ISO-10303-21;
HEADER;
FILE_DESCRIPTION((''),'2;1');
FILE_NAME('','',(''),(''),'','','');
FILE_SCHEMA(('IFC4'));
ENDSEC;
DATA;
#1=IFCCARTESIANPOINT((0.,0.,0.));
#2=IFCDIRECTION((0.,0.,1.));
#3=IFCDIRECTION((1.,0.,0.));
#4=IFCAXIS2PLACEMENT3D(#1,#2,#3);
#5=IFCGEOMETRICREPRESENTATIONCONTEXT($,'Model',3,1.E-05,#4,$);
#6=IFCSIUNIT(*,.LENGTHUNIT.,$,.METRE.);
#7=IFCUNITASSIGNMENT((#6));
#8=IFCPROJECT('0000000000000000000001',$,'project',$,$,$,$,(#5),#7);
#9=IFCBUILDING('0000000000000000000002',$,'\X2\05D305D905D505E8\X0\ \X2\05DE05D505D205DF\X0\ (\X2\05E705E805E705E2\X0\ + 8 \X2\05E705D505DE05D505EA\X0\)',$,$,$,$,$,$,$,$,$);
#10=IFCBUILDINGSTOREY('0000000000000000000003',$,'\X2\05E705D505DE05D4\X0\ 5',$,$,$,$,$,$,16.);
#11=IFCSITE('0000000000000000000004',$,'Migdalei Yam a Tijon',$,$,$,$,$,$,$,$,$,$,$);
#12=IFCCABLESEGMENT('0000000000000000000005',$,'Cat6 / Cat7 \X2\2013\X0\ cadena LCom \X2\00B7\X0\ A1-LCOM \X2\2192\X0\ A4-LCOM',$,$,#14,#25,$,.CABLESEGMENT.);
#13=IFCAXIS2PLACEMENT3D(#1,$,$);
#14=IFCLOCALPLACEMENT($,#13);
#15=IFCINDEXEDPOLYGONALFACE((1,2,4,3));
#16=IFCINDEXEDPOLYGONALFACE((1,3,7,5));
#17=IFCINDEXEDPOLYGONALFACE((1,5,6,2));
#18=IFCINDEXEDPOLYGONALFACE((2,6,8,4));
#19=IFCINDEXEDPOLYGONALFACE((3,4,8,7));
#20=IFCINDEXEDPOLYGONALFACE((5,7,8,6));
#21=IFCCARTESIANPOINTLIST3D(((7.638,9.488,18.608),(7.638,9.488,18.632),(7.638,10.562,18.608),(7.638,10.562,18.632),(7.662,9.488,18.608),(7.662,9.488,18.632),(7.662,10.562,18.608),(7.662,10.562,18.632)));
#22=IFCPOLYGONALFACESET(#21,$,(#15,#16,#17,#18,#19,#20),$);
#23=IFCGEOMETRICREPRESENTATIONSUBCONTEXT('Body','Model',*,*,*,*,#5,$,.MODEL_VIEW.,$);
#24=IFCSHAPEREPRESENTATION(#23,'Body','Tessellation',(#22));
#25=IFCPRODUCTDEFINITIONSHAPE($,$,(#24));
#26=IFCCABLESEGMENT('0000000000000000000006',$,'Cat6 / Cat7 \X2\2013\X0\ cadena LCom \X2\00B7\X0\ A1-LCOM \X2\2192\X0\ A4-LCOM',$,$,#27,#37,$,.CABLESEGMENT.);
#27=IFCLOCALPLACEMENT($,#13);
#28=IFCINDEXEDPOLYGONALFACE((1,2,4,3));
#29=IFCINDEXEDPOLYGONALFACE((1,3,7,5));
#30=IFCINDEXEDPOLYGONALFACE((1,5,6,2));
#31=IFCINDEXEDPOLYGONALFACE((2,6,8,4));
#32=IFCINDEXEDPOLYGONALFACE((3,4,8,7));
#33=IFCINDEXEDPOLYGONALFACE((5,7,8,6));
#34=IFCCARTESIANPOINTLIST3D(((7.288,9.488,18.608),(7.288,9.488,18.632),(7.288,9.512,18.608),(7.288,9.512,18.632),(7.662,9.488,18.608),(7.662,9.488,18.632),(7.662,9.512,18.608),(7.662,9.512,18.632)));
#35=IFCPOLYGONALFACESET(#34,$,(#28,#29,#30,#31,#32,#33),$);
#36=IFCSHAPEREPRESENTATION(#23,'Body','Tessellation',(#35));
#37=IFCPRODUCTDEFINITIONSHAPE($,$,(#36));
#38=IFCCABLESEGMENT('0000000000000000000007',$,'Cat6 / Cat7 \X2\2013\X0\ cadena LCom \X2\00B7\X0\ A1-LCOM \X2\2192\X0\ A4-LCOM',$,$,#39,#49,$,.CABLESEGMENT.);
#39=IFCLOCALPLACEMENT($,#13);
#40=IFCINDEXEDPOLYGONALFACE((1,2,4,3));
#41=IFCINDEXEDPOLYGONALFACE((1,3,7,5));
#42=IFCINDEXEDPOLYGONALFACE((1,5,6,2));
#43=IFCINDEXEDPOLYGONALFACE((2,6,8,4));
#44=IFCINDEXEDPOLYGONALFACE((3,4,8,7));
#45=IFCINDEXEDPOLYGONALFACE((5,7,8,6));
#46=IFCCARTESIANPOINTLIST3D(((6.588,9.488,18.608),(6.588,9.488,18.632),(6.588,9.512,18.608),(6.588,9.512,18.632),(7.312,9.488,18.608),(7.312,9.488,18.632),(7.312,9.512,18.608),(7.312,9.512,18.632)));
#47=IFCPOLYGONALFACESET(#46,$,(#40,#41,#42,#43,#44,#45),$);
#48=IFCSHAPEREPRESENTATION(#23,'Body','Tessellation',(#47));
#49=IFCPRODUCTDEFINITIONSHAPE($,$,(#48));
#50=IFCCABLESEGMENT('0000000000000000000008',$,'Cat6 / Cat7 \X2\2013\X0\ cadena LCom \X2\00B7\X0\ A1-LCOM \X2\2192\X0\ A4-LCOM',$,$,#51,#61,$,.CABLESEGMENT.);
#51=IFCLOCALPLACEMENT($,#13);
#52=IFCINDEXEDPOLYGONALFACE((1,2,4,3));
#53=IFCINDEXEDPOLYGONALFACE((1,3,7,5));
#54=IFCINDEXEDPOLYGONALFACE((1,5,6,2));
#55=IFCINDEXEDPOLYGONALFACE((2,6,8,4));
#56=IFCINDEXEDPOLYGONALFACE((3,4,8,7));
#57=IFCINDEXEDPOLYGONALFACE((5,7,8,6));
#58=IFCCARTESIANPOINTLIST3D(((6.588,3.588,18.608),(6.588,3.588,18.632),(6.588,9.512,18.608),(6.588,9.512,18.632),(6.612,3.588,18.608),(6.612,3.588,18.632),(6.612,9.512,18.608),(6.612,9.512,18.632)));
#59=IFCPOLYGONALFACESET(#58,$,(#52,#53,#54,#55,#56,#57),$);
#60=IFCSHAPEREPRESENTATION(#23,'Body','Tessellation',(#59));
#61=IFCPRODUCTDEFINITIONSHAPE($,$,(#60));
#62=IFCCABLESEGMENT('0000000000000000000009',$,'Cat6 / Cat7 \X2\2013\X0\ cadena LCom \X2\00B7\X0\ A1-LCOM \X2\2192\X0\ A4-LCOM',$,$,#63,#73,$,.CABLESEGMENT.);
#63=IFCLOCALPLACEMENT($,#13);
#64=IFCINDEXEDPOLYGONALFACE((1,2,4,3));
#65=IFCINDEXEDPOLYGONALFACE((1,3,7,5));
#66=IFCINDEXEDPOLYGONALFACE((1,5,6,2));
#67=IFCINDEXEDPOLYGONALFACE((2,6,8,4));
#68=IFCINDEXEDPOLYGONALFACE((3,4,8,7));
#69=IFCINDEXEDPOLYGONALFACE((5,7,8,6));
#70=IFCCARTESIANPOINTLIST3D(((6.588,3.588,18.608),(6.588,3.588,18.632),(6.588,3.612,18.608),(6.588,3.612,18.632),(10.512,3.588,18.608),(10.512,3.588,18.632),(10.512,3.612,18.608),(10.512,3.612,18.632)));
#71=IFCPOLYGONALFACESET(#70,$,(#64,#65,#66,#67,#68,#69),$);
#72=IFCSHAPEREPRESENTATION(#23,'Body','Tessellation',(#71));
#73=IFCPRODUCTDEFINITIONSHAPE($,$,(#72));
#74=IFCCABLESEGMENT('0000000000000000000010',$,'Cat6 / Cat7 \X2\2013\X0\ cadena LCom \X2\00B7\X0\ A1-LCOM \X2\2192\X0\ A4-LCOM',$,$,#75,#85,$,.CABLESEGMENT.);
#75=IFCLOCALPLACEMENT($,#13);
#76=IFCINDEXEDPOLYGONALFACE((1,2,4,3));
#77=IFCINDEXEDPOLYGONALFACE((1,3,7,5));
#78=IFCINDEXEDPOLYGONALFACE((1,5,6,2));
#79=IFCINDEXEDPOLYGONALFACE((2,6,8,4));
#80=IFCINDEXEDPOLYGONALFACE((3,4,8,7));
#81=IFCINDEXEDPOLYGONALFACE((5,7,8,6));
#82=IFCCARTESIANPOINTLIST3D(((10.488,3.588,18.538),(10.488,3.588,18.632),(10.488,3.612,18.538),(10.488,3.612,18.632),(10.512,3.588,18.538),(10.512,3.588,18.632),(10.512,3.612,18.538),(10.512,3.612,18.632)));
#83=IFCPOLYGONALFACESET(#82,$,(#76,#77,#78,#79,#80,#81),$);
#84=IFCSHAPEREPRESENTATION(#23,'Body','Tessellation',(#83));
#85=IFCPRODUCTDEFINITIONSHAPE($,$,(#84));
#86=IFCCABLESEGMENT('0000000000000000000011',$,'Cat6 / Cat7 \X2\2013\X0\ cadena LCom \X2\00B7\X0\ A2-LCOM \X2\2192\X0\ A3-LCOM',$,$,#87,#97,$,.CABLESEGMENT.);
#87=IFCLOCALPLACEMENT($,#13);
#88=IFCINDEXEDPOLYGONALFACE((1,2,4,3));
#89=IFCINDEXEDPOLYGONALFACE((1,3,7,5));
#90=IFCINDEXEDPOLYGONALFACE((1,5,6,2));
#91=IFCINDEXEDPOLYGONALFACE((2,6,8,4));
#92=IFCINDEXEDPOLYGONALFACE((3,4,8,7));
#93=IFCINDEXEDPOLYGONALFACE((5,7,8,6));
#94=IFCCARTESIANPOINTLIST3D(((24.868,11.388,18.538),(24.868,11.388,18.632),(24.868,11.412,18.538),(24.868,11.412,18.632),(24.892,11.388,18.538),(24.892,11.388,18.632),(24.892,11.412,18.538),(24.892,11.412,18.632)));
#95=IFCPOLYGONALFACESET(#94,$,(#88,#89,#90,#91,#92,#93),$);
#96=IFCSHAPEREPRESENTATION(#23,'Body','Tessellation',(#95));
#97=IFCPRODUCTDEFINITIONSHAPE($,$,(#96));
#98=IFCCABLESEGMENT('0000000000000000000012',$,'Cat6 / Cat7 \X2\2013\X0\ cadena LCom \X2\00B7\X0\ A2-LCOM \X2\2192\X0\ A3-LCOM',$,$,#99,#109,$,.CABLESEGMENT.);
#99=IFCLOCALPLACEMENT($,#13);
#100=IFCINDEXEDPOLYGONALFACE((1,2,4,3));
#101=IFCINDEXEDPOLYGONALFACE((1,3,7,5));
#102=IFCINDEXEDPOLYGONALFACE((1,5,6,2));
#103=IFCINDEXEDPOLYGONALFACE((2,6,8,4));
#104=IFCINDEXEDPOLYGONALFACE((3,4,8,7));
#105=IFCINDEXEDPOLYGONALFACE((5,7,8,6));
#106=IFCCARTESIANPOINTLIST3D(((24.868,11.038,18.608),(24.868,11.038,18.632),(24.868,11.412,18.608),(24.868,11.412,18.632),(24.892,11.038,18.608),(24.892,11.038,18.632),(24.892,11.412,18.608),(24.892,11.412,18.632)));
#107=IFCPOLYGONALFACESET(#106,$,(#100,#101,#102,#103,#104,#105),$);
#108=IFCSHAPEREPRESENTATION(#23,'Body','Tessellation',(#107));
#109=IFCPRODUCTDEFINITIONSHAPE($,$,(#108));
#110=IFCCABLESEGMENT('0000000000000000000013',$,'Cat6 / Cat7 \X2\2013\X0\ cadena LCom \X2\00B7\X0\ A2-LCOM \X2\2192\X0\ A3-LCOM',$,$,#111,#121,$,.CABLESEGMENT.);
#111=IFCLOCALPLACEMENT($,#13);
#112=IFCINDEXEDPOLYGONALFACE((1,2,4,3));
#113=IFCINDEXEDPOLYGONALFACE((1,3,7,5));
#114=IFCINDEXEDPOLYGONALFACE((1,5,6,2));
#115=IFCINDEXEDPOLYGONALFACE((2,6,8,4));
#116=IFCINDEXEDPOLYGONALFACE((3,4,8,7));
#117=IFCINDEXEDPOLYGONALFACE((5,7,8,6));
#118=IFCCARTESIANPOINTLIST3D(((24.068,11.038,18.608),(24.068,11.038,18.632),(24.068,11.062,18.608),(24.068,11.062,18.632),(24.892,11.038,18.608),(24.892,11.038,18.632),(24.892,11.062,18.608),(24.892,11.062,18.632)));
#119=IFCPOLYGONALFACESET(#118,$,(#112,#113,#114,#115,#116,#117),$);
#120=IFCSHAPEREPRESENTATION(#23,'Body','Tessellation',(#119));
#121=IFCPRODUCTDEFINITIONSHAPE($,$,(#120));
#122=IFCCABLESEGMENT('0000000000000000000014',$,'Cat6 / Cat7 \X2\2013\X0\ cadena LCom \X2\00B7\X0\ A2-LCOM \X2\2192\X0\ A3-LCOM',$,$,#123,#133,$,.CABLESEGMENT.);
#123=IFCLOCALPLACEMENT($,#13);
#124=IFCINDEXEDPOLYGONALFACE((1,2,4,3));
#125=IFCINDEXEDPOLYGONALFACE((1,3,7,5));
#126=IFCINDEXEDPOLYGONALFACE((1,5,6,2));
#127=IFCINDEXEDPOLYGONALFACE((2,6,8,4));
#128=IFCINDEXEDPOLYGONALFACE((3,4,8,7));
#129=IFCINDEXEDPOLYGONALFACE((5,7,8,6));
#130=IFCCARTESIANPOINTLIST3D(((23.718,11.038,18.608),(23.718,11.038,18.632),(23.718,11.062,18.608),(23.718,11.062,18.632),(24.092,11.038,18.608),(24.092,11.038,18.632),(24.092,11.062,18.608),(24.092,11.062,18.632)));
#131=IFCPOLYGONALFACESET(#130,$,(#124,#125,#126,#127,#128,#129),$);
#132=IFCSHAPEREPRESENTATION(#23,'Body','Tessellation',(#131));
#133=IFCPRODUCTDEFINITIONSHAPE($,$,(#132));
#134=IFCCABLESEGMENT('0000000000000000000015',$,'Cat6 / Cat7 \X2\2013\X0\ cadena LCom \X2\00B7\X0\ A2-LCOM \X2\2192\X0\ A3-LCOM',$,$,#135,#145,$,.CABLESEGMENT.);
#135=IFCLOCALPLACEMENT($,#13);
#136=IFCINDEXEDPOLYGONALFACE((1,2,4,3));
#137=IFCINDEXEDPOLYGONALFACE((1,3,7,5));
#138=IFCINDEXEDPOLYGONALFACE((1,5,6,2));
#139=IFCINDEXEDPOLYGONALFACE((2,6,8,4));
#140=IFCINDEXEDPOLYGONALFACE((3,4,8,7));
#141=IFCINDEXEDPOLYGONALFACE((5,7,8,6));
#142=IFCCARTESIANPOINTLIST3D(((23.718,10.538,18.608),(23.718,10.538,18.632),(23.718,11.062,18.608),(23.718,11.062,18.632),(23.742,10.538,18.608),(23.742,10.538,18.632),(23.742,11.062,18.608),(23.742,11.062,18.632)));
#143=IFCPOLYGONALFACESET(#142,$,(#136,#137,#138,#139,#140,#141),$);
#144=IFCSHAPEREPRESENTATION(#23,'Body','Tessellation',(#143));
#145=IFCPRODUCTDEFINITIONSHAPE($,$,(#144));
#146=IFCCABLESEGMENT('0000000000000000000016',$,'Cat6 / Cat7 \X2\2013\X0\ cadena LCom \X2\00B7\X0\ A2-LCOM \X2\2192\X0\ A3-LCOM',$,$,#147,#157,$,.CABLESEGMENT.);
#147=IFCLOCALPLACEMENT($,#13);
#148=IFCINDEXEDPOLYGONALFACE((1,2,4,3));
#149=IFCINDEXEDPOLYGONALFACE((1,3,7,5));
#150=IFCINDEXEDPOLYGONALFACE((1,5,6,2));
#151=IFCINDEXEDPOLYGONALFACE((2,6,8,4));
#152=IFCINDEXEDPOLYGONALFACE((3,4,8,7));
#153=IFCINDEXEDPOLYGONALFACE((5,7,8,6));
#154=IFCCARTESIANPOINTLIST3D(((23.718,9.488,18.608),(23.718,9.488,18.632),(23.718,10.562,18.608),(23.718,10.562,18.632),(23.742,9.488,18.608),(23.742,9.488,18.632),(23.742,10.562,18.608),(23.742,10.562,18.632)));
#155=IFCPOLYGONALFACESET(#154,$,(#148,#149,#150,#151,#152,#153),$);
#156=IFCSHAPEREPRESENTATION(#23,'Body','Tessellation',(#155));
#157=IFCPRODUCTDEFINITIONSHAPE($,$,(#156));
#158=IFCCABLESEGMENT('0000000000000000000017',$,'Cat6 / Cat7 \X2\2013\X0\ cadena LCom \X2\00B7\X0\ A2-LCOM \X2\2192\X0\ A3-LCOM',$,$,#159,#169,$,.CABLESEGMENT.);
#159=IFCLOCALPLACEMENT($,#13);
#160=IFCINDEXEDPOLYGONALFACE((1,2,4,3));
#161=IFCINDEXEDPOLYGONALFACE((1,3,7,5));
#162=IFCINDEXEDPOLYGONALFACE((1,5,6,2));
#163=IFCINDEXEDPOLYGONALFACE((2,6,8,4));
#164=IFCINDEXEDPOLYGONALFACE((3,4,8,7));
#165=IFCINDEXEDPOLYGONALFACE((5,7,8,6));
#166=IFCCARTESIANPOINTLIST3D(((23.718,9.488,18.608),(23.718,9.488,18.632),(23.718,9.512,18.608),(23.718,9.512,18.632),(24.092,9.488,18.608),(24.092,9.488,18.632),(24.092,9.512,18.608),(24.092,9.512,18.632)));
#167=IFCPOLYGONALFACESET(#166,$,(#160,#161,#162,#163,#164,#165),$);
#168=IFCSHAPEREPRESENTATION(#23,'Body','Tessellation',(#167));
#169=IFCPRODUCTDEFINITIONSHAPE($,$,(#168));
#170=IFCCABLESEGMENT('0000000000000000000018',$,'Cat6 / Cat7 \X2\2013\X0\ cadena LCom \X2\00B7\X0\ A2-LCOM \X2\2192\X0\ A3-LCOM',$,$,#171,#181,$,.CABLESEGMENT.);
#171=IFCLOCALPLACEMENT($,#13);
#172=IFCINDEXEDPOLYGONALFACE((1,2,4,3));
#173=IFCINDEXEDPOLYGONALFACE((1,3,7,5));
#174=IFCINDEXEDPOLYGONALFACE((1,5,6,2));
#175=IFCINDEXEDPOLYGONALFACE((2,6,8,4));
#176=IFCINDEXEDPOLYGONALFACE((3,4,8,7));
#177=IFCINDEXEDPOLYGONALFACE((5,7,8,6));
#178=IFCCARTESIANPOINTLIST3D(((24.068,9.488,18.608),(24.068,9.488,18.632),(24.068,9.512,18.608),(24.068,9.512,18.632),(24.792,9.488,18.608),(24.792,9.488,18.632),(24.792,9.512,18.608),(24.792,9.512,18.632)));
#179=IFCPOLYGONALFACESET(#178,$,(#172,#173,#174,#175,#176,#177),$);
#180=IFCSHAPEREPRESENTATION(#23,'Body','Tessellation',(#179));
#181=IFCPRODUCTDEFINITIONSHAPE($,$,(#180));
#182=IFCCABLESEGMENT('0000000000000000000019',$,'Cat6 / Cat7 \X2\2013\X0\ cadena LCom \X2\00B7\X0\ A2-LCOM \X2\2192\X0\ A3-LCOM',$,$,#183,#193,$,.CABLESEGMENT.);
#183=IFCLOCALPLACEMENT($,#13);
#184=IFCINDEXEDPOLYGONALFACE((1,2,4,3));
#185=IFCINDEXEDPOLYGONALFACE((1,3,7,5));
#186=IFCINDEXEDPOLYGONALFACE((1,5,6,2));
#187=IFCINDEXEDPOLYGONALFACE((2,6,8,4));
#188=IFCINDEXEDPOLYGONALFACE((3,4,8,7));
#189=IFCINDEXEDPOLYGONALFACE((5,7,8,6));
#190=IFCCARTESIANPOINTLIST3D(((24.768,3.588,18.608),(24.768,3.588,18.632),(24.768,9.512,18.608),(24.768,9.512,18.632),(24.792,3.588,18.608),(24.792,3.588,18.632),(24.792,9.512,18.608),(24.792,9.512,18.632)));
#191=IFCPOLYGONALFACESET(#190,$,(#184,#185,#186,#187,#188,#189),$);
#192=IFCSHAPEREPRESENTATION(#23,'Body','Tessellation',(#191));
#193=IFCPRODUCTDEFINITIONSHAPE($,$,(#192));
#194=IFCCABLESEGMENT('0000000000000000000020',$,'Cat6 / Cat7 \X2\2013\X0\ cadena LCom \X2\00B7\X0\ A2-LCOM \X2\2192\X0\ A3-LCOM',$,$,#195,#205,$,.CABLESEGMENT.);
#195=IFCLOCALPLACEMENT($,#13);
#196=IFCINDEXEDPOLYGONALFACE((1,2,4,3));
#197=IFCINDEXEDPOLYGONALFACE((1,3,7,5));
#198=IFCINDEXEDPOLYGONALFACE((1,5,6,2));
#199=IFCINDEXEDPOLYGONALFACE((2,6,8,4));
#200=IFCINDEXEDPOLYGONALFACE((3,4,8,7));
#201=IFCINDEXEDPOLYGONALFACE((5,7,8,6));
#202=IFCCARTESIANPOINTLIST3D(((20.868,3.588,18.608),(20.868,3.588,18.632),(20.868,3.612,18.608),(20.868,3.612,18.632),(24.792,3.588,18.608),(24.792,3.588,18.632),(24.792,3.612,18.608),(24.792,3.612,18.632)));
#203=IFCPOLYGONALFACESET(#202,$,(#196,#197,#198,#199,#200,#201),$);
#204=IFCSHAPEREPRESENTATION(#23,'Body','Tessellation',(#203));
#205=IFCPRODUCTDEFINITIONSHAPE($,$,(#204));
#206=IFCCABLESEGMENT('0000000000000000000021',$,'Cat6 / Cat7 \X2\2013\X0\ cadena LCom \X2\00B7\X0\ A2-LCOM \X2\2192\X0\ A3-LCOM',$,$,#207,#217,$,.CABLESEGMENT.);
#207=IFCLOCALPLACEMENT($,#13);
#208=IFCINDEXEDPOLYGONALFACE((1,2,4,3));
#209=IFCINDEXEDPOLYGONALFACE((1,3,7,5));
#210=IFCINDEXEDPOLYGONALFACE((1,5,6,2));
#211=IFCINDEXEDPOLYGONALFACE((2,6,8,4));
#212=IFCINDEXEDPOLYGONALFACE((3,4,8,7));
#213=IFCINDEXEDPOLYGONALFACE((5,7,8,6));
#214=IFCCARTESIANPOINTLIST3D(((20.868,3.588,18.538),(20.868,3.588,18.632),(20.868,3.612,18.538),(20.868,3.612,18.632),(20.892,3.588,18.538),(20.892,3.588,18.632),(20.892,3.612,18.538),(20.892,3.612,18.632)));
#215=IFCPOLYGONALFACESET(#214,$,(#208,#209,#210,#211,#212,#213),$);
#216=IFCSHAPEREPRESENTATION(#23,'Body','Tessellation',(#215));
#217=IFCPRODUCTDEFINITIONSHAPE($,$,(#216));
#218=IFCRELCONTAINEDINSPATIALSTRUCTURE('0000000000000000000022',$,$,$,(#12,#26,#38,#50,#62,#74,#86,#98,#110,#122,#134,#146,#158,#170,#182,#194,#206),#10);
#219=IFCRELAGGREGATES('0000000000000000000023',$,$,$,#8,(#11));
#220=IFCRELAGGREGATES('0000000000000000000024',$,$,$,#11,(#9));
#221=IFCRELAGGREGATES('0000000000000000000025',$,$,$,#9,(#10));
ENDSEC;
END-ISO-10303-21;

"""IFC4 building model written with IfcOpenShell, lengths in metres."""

from ifc_helpers import new_model, si_unit, frame, origin_with_axes, context, subcontext, project, spatial, line, indexed_curve, outline, extrude, element, save


model = new_model("IFC4")

# Units and contexts
model_context = context("Model", 3, precision=1e-05, world=origin_with_axes())
body_context = subcontext(model_context, "Body", "Model", "MODEL_VIEW")
ifc_project = project(units=[si_unit("LENGTHUNIT", "METRE")], contexts=[model_context])

# Site, building, storey
site = spatial("IfcSite", under=ifc_project, Name="Migdalei Yam a Tijon")
building = spatial("IfcBuilding", under=site, Name="דיור מוגן (קרקע + 8 קומות)")
storey = spatial("IfcBuildingStorey", under=building, Name="קומה 5", Elevation=16.0)

# Cable segments
element("IfcCableSegment", 1, inside=storey, Name="Cat6 / Cat7 – cadena LCom · A1-LCOM → A4-LCOM", PredefinedType="CABLESEGMENT", context=body_context, shape_type="SweptSolid", body=[
    extrude(outline(indexed_curve([(0.0, 0.0), (0.024, 0.0), (0.024, 1.074), (0.0, 1.074)], segments=[line(1, 2, 3, 4, 1)])), frame((7.638, 9.488, 18.608), z_axis=(0.0, 0.0, 1.0), x_axis=(1.0, 0.0, 0.0)), (0.0, 0.0, 1.0), 0.024),
])
element("IfcCableSegment", 2, inside=storey, Name="Cat6 / Cat7 – cadena LCom · A1-LCOM → A4-LCOM", PredefinedType="CABLESEGMENT", context=body_context, shape_type="SweptSolid", body=[
    extrude(outline(indexed_curve([(0.0, 0.0), (0.374, 0.0), (0.374, 0.024), (0.0, 0.024)], segments=[line(1, 2, 3, 4, 1)])), frame((7.288, 9.488, 18.608), z_axis=(0.0, 0.0, 1.0), x_axis=(1.0, 0.0, 0.0)), (0.0, 0.0, 1.0), 0.024),
])
element("IfcCableSegment", 3, inside=storey, Name="Cat6 / Cat7 – cadena LCom · A1-LCOM → A4-LCOM", PredefinedType="CABLESEGMENT", context=body_context, shape_type="SweptSolid", body=[
    extrude(outline(indexed_curve([(0.0, 0.0), (0.724, 0.0), (0.724, 0.024), (0.0, 0.024)], segments=[line(1, 2, 3, 4, 1)])), frame((6.588, 9.488, 18.608), z_axis=(0.0, 0.0, 1.0), x_axis=(1.0, 0.0, 0.0)), (0.0, 0.0, 1.0), 0.024),
])
element("IfcCableSegment", 4, inside=storey, Name="Cat6 / Cat7 – cadena LCom · A1-LCOM → A4-LCOM", PredefinedType="CABLESEGMENT", context=body_context, shape_type="SweptSolid", body=[
    extrude(outline(indexed_curve([(0.0, 0.0), (0.024, 0.0), (0.024, 5.924), (0.0, 5.924)], segments=[line(1, 2, 3, 4, 1)])), frame((6.588, 3.588, 18.608), z_axis=(0.0, 0.0, 1.0), x_axis=(1.0, 0.0, 0.0)), (0.0, 0.0, 1.0), 0.024),
])
element("IfcCableSegment", 5, inside=storey, Name="Cat6 / Cat7 – cadena LCom · A1-LCOM → A4-LCOM", PredefinedType="CABLESEGMENT", context=body_context, shape_type="SweptSolid", body=[
    extrude(outline(indexed_curve([(0.0, 0.0), (3.924, 0.0), (3.924, 0.024), (0.0, 0.024)], segments=[line(1, 2, 3, 4, 1)])), frame((6.588, 3.588, 18.608), z_axis=(0.0, 0.0, 1.0), x_axis=(1.0, 0.0, 0.0)), (0.0, 0.0, 1.0), 0.024),
])
element("IfcCableSegment", 6, inside=storey, Name="Cat6 / Cat7 – cadena LCom · A1-LCOM → A4-LCOM", PredefinedType="CABLESEGMENT", context=body_context, shape_type="SweptSolid", body=[
    extrude(outline(indexed_curve([(0.0, 0.0), (0.024, 0.0), (0.024, 0.024), (0.0, 0.024)], segments=[line(1, 2, 3, 4, 1)])), frame((10.488, 3.588, 18.538), z_axis=(0.0, 0.0, 1.0), x_axis=(1.0, 0.0, 0.0)), (0.0, 0.0, 1.0), 0.094),
])
element("IfcCableSegment", 7, inside=storey, Name="Cat6 / Cat7 – cadena LCom · A2-LCOM → A3-LCOM", PredefinedType="CABLESEGMENT", context=body_context, shape_type="SweptSolid", body=[
    extrude(outline(indexed_curve([(0.0, 0.0), (0.024, 0.0), (0.024, 0.024), (0.0, 0.024)], segments=[line(1, 2, 3, 4, 1)])), frame((24.868, 11.388, 18.538), z_axis=(0.0, 0.0, 1.0), x_axis=(1.0, 0.0, 0.0)), (0.0, 0.0, 1.0), 0.094),
])
element("IfcCableSegment", 8, inside=storey, Name="Cat6 / Cat7 – cadena LCom · A2-LCOM → A3-LCOM", PredefinedType="CABLESEGMENT", context=body_context, shape_type="SweptSolid", body=[
    extrude(outline(indexed_curve([(0.0, 0.0), (0.024, 0.0), (0.024, 0.374), (0.0, 0.374)], segments=[line(1, 2, 3, 4, 1)])), frame((24.868, 11.038, 18.608), z_axis=(0.0, 0.0, 1.0), x_axis=(1.0, 0.0, 0.0)), (0.0, 0.0, 1.0), 0.024),
])
element("IfcCableSegment", 9, inside=storey, Name="Cat6 / Cat7 – cadena LCom · A2-LCOM → A3-LCOM", PredefinedType="CABLESEGMENT", context=body_context, shape_type="SweptSolid", body=[
    extrude(outline(indexed_curve([(0.0, 0.0), (0.824, 0.0), (0.824, 0.024), (0.0, 0.024)], segments=[line(1, 2, 3, 4, 1)])), frame((24.068, 11.038, 18.608), z_axis=(0.0, 0.0, 1.0), x_axis=(1.0, 0.0, 0.0)), (0.0, 0.0, 1.0), 0.024),
])
element("IfcCableSegment", 10, inside=storey, Name="Cat6 / Cat7 – cadena LCom · A2-LCOM → A3-LCOM", PredefinedType="CABLESEGMENT", context=body_context, shape_type="SweptSolid", body=[
    extrude(outline(indexed_curve([(0.0, 0.0), (0.374, 0.0), (0.374, 0.024), (0.0, 0.024)], segments=[line(1, 2, 3, 4, 1)])), frame((23.718, 11.038, 18.608), z_axis=(0.0, 0.0, 1.0), x_axis=(1.0, 0.0, 0.0)), (0.0, 0.0, 1.0), 0.024),
])
element("IfcCableSegment", 11, inside=storey, Name="Cat6 / Cat7 – cadena LCom · A2-LCOM → A3-LCOM", PredefinedType="CABLESEGMENT", context=body_context, shape_type="SweptSolid", body=[
    extrude(outline(indexed_curve([(0.0, 0.0), (0.024, 0.0), (0.024, 0.524), (0.0, 0.524)], segments=[line(1, 2, 3, 4, 1)])), frame((23.718, 10.538, 18.608), z_axis=(0.0, 0.0, 1.0), x_axis=(1.0, 0.0, 0.0)), (0.0, 0.0, 1.0), 0.024),
])
element("IfcCableSegment", 12, inside=storey, Name="Cat6 / Cat7 – cadena LCom · A2-LCOM → A3-LCOM", PredefinedType="CABLESEGMENT", context=body_context, shape_type="SweptSolid", body=[
    extrude(outline(indexed_curve([(0.0, 0.0), (0.024, 0.0), (0.024, 1.074), (0.0, 1.074)], segments=[line(1, 2, 3, 4, 1)])), frame((23.718, 9.488, 18.608), z_axis=(0.0, 0.0, 1.0), x_axis=(1.0, 0.0, 0.0)), (0.0, 0.0, 1.0), 0.024),
])
element("IfcCableSegment", 13, inside=storey, Name="Cat6 / Cat7 – cadena LCom · A2-LCOM → A3-LCOM", PredefinedType="CABLESEGMENT", context=body_context, shape_type="SweptSolid", body=[
    extrude(outline(indexed_curve([(0.0, 0.0), (0.374, 0.0), (0.374, 0.024), (0.0, 0.024)], segments=[line(1, 2, 3, 4, 1)])), frame((23.718, 9.488, 18.608), z_axis=(0.0, 0.0, 1.0), x_axis=(1.0, 0.0, 0.0)), (0.0, 0.0, 1.0), 0.024),
])
element("IfcCableSegment", 14, inside=storey, Name="Cat6 / Cat7 – cadena LCom · A2-LCOM → A3-LCOM", PredefinedType="CABLESEGMENT", context=body_context, shape_type="SweptSolid", body=[
    extrude(outline(indexed_curve([(0.0, 0.0), (0.724, 0.0), (0.724, 0.024), (0.0, 0.024)], segments=[line(1, 2, 3, 4, 1)])), frame((24.068, 9.488, 18.608), z_axis=(0.0, 0.0, 1.0), x_axis=(1.0, 0.0, 0.0)), (0.0, 0.0, 1.0), 0.024),
])
element("IfcCableSegment", 15, inside=storey, Name="Cat6 / Cat7 – cadena LCom · A2-LCOM → A3-LCOM", PredefinedType="CABLESEGMENT", context=body_context, shape_type="SweptSolid", body=[
    extrude(outline(indexed_curve([(0.0, 0.0), (0.024, 0.0), (0.024, 5.924), (0.0, 5.924)], segments=[line(1, 2, 3, 4, 1)])), frame((24.768, 3.588, 18.608), z_axis=(0.0, 0.0, 1.0), x_axis=(1.0, 0.0, 0.0)), (0.0, 0.0, 1.0), 0.024),
])
element("IfcCableSegment", 16, inside=storey, Name="Cat6 / Cat7 – cadena LCom · A2-LCOM → A3-LCOM", PredefinedType="CABLESEGMENT", context=body_context, shape_type="SweptSolid", body=[
    extrude(outline(indexed_curve([(0.0, 0.0), (3.924, 0.0), (3.924, 0.024), (0.0, 0.024)], segments=[line(1, 2, 3, 4, 1)])), frame((20.868, 3.588, 18.608), z_axis=(0.0, 0.0, 1.0), x_axis=(1.0, 0.0, 0.0)), (0.0, 0.0, 1.0), 0.024),
])
element("IfcCableSegment", 17, inside=storey, Name="Cat6 / Cat7 – cadena LCom · A2-LCOM → A3-LCOM", PredefinedType="CABLESEGMENT", context=body_context, shape_type="SweptSolid", body=[
    extrude(outline(indexed_curve([(0.0, 0.0), (0.024, 0.0), (0.024, 0.024), (0.0, 0.024)], segments=[line(1, 2, 3, 4, 1)])), frame((20.868, 3.588, 18.538), z_axis=(0.0, 0.0, 1.0), x_axis=(1.0, 0.0, 0.0)), (0.0, 0.0, 1.0), 0.094),
])

save(model, "model.ifc")
